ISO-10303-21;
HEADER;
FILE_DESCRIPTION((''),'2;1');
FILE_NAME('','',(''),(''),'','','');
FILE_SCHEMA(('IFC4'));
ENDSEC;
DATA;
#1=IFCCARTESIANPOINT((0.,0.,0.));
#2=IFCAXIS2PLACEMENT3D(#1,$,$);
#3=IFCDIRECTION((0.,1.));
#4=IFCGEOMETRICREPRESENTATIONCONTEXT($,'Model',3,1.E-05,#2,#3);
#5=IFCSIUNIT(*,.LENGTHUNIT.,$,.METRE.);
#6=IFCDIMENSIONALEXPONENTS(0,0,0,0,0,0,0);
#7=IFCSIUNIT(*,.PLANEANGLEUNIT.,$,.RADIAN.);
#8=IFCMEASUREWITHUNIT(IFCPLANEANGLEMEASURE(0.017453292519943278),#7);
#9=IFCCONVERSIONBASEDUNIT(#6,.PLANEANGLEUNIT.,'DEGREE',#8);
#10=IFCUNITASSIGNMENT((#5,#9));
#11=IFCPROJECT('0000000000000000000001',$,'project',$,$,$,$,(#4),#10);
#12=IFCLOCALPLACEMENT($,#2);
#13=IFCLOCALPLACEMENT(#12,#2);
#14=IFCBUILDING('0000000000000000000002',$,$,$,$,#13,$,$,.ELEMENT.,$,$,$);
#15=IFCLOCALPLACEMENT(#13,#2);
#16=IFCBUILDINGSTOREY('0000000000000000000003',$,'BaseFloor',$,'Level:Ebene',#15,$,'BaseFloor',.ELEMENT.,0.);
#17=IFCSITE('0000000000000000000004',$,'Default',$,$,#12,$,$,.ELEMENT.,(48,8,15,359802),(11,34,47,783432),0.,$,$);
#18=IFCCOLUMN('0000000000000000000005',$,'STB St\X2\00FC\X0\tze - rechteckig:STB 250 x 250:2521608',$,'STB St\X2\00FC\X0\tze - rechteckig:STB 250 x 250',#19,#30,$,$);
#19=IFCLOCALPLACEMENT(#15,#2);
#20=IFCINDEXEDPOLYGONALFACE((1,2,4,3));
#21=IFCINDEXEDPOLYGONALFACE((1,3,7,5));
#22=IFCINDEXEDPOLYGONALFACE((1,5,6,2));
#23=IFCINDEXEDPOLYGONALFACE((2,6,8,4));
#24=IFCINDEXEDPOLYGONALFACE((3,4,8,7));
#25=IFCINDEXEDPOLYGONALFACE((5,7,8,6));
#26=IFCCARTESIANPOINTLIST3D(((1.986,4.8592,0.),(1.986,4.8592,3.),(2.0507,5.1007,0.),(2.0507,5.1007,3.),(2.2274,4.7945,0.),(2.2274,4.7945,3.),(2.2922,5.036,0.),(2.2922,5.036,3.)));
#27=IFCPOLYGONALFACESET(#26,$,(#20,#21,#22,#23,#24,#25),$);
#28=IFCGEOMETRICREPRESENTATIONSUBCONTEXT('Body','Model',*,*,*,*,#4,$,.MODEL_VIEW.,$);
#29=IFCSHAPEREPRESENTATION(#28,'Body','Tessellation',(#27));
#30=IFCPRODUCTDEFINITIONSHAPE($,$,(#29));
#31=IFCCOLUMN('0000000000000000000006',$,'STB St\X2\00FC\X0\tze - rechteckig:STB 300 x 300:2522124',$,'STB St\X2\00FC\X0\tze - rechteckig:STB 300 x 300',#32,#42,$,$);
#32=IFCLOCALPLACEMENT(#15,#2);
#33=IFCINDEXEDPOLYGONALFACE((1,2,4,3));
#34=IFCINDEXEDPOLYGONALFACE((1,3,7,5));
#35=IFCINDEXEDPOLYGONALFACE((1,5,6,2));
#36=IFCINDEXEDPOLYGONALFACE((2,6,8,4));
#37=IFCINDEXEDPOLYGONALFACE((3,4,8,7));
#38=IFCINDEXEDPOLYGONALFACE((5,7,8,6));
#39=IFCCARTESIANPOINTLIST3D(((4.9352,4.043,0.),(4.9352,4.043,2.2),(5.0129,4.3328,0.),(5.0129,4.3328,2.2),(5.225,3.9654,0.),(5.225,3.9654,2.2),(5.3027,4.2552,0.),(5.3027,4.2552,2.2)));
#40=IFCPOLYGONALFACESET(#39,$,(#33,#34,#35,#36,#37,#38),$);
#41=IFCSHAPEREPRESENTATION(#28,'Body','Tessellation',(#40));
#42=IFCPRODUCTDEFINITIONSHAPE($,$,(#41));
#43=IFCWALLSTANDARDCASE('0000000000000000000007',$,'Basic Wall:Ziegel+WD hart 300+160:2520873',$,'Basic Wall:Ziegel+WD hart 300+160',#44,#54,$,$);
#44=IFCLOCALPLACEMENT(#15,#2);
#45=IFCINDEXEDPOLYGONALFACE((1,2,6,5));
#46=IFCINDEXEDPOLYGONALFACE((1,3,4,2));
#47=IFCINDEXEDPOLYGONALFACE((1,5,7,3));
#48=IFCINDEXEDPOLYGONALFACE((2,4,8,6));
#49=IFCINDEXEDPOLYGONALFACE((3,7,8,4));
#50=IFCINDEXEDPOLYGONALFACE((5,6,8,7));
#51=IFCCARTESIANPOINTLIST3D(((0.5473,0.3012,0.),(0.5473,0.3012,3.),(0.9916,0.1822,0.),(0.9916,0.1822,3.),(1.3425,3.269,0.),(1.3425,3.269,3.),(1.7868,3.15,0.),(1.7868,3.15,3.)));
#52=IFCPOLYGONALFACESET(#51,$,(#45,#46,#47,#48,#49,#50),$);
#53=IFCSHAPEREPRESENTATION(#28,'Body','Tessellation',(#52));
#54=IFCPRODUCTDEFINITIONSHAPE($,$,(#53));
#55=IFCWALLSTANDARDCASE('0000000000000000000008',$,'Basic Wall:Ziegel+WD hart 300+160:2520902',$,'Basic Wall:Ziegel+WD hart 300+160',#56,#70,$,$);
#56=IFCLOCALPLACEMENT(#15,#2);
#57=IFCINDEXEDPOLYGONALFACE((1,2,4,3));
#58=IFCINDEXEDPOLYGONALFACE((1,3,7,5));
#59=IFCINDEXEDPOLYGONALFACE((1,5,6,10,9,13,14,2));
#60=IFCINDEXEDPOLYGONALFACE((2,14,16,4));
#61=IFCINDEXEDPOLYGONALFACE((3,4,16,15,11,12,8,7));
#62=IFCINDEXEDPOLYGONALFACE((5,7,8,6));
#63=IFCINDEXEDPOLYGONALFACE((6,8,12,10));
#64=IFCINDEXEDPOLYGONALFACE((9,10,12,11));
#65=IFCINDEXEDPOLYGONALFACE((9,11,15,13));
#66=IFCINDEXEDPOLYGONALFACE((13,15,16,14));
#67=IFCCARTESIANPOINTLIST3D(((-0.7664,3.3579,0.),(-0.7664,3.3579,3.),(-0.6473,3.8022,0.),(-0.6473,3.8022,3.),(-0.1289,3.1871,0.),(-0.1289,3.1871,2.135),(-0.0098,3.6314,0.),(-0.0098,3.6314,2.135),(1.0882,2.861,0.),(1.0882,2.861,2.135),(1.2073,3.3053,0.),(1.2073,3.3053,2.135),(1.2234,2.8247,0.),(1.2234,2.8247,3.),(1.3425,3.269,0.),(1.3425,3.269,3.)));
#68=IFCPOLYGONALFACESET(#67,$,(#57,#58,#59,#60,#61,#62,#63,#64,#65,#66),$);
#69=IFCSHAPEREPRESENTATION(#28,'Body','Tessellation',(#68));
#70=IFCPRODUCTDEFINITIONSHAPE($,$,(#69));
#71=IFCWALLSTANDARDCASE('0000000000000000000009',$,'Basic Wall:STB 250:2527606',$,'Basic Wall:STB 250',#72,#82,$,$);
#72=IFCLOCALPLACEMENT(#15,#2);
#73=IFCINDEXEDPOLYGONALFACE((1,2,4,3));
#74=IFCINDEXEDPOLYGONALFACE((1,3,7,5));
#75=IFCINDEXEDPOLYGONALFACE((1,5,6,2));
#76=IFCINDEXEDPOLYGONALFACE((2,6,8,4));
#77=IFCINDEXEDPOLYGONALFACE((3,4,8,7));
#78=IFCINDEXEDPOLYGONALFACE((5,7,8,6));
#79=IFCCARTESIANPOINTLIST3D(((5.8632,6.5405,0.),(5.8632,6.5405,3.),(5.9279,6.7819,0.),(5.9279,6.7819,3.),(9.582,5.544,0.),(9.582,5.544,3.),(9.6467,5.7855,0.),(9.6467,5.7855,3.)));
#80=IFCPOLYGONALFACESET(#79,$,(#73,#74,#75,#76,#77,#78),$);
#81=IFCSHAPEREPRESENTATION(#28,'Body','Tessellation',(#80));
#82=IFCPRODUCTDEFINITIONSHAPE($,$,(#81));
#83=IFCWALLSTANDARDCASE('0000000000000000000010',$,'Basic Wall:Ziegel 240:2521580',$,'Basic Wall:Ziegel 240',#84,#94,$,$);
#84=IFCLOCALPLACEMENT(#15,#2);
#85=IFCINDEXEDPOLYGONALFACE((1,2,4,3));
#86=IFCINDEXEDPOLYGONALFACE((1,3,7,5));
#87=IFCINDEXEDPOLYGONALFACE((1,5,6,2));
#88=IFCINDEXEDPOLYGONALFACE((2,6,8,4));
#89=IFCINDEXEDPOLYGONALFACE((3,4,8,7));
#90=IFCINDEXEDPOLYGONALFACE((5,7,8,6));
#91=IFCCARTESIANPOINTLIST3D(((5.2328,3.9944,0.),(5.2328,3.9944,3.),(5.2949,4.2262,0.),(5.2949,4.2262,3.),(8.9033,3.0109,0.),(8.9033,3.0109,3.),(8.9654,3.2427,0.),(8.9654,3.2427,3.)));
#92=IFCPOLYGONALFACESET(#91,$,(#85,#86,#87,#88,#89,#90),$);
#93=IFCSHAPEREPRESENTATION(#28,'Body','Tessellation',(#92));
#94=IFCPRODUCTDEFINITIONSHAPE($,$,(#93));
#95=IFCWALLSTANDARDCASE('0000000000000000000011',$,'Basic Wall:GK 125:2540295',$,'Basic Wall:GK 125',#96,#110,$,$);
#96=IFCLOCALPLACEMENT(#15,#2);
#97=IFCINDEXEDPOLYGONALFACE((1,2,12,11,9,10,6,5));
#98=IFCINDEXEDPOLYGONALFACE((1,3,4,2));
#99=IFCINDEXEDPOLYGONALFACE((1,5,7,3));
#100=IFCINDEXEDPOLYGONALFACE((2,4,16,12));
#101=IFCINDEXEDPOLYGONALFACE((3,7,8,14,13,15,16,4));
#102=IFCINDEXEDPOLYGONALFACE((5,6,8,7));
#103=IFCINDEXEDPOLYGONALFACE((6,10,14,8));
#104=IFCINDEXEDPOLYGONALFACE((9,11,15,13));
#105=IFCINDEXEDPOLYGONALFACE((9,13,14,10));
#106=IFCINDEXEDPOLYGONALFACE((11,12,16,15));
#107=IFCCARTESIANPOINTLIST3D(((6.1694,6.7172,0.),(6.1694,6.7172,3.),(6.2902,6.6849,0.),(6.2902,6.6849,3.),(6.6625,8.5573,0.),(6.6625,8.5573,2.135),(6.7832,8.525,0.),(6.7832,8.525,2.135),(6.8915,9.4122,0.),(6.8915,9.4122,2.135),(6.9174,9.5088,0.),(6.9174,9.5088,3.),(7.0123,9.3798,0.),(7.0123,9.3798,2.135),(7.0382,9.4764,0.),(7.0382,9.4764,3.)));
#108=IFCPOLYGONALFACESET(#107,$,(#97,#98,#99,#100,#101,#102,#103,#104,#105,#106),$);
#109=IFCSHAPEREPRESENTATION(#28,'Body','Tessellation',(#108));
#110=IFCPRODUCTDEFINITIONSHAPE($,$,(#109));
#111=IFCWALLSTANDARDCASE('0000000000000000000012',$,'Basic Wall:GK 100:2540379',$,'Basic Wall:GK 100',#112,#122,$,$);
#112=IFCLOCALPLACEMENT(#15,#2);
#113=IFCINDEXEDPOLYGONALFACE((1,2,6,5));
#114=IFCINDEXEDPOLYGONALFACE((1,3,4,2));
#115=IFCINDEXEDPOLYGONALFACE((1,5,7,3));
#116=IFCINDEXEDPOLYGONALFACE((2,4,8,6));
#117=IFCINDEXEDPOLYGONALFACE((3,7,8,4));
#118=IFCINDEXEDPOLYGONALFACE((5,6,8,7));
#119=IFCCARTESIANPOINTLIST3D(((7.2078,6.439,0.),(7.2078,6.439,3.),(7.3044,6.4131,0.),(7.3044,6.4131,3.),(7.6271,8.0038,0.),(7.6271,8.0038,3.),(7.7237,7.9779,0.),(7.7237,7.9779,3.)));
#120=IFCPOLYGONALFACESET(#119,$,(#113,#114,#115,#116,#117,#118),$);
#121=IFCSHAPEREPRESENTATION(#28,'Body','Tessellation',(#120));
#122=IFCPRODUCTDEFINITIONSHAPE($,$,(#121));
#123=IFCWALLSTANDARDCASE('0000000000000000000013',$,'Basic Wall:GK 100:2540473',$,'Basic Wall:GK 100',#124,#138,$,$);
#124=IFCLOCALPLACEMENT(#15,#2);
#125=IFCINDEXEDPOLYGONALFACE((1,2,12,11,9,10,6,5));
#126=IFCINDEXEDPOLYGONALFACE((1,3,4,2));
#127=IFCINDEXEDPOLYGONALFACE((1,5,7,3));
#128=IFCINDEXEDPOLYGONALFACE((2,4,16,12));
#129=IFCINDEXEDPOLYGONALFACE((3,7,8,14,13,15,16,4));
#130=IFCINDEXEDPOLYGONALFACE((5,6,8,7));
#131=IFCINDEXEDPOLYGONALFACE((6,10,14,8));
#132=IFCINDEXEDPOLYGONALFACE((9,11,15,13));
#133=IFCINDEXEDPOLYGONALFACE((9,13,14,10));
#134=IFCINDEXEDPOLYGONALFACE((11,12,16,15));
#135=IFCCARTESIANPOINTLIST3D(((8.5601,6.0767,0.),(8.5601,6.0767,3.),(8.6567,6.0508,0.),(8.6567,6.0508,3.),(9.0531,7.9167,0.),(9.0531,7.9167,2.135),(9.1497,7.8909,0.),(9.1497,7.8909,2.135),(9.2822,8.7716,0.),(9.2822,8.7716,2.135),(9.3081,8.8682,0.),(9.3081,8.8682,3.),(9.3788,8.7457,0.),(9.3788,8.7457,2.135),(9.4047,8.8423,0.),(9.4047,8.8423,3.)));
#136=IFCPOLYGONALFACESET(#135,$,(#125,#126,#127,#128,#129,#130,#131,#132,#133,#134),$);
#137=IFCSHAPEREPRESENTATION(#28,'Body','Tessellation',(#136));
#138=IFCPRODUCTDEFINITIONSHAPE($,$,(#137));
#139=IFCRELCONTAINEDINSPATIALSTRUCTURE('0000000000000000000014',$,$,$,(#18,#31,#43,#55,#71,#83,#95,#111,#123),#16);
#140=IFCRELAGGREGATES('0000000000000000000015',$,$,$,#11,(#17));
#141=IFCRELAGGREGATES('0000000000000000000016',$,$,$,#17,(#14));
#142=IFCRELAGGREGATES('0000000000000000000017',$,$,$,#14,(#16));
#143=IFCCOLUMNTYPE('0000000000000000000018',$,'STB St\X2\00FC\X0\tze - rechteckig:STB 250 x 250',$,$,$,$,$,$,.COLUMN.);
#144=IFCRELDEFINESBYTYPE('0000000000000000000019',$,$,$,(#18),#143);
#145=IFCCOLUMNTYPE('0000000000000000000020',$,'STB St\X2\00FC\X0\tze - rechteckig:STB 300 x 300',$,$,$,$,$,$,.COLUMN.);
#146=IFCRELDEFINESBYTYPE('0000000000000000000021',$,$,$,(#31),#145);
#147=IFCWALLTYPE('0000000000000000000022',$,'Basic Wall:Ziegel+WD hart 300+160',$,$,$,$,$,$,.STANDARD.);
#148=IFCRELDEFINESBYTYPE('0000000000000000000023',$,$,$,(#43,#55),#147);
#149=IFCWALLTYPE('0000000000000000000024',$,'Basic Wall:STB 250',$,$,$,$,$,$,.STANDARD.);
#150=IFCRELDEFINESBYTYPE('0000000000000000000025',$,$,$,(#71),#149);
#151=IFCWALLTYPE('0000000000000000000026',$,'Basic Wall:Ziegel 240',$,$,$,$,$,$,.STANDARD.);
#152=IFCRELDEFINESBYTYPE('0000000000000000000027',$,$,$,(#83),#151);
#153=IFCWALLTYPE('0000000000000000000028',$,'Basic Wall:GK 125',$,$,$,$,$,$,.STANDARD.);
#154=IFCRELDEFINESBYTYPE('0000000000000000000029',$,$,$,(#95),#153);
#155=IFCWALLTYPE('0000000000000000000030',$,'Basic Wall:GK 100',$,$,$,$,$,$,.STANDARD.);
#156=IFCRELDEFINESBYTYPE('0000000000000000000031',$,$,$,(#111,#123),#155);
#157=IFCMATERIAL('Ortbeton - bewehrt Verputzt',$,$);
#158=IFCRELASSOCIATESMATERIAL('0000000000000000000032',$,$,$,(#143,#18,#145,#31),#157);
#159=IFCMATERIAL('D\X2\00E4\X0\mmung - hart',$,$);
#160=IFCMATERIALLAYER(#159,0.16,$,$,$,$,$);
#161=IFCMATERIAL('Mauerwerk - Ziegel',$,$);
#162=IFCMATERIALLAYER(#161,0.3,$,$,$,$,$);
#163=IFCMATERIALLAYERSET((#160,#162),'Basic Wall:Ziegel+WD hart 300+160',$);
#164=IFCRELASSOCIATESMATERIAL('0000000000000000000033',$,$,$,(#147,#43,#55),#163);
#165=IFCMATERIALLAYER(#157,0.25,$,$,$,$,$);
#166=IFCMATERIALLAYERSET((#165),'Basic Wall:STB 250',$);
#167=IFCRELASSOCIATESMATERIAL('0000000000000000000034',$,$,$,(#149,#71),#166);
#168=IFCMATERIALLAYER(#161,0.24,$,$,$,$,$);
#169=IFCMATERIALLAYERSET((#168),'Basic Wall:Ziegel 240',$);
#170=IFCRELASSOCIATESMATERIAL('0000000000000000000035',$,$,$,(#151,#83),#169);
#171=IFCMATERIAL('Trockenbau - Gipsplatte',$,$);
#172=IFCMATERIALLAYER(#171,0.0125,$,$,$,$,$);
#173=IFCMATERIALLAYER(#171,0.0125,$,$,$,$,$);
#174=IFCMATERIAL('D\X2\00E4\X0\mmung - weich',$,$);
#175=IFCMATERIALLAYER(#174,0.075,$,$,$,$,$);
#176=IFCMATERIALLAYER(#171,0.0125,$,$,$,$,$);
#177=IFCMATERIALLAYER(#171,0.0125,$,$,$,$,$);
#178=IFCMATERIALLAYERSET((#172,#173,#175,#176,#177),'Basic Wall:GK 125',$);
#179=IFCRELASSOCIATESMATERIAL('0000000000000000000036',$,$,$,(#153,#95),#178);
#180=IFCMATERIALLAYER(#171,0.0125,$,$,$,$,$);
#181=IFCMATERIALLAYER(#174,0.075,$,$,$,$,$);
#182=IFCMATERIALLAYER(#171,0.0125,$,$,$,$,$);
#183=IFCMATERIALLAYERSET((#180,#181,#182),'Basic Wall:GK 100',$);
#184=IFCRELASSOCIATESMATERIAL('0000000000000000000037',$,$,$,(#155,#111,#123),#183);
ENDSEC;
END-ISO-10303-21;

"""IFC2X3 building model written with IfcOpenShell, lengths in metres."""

from ifc_helpers import new_model, entity, si_unit, converted_unit, direction, frame, frame_2d, origin, place, context, subcontext, project, spatial, rectangle, extrude, source, transform, mapped, material, layer, layer_set, layer_usage, type_object, type_shapes, element, save


model = new_model("IFC2X3")

# Units and contexts
model_context = context("Model", 3, precision=1e-05, world=origin(), true_north=direction((0.0, 1.0)))
body_context = subcontext(model_context, "Body", "Model", "MODEL_VIEW")
ifc_project = project(units=[si_unit("LENGTHUNIT", "METRE"), converted_unit("PLANEANGLEUNIT", "DEGREE", entity("IfcPlaneAngleMeasure", 0.017453292519943278), si_unit("PLANEANGLEUNIT", "RADIAN"), dimensions=[0, 0, 0, 0, 0, 0, 0])], contexts=[model_context])

# Site, building, storey
site_placement = place(None, origin())
site = spatial("IfcSite", under=ifc_project, at=site_placement, Name="Default", CompositionType="ELEMENT", RefLatitude=(48, 8, 15, 359802), RefLongitude=(11, 34, 47, 783432), RefElevation=0.0)
building_placement = place(site_placement, origin())
building = spatial("IfcBuilding", under=site, at=building_placement, CompositionType="ELEMENT")
storey_placement = place(building_placement, origin())
storey = spatial("IfcBuildingStorey", under=building, at=storey_placement, Name="BaseFloor", ObjectType="Level:Ebene", LongName="BaseFloor", CompositionType="ELEMENT", Elevation=0.0)

# Columns
ifc_material_1 = material(Name="Ortbeton - bewehrt Verputzt")
column_type_1 = type_object("IfcColumnType", Name="STB Stütze - rechteckig:STB 250 x 250", PredefinedType="COLUMN", material=ifc_material_1)
shared_shape_1 = source(origin(), body_context, "Body", "SweptSolid", [
    extrude(rectangle(XDim=0.25, YDim=0.25, at=frame_2d((0.0, 0.0), x_axis=(1.0, 0.0))), frame((2.1391, 4.9476, 0.0), z_axis=(0.0, 0.0, 1.0), x_axis=(-0.258819, -0.965926, 0.0)), (0.0, 0.0, 1.0), 3.0),
])
type_shapes(column_type_1, [shared_shape_1])
column_1_placement = place(storey_placement, origin())
element("IfcColumn", 1, at=column_1_placement, inside=storey, type_object=column_type_1, material=ifc_material_1, Name="STB Stütze - rechteckig:STB 250 x 250:2521608", ObjectType="STB Stütze - rechteckig:STB 250 x 250", context=body_context, shape_type="MappedRepresentation", body=[
    mapped(shared_shape_1, transform((0.0, 0.0, 0.0), scale=1.0)),
])
column_type_2 = type_object("IfcColumnType", Name="STB Stütze - rechteckig:STB 300 x 300", PredefinedType="COLUMN", material=ifc_material_1)
shared_shape_2 = source(origin(), body_context, "Body", "SweptSolid", [
    extrude(rectangle(XDim=0.3, YDim=0.3, at=frame_2d((0.0, 0.0), x_axis=(1.0, 0.0))), frame((5.1189, 4.1491, 0.0), z_axis=(0.0, 0.0, 1.0), x_axis=(-0.258819, -0.965926, 0.0)), (0.0, 0.0, 1.0), 2.2),
])
type_shapes(column_type_2, [shared_shape_2])
column_2_placement = place(storey_placement, origin())
element("IfcColumn", 2, at=column_2_placement, inside=storey, type_object=column_type_2, material=ifc_material_1, Name="STB Stütze - rechteckig:STB 300 x 300:2522124", ObjectType="STB Stütze - rechteckig:STB 300 x 300", context=body_context, shape_type="MappedRepresentation", body=[
    mapped(shared_shape_2, transform((0.0, 0.0, 0.0), scale=1.0)),
])

# Wall
ifc_material_2 = material(Name="Dämmung - hart")
ifc_layer_1 = layer(ifc_material_2, 0.16)
ifc_material_3 = material(Name="Mauerwerk - Ziegel")
ifc_layer_2 = layer(ifc_material_3, 0.3)
ifc_layer_set_1 = layer_set([ifc_layer_1, ifc_layer_2], Name="Basic Wall:Ziegel+WD hart 300+160")
ifc_layer_usage_1 = layer_usage(ifc_layer_set_1, "AXIS2", "NEGATIVE", 0.23)
wall_type_1 = type_object("IfcWallType", Name="Basic Wall:Ziegel+WD hart 300+160", PredefinedType="STANDARD", material=ifc_layer_set_1)
wall_1_placement = place(storey_placement, frame((0.7694, 0.2417, 0.0), z_axis=(0.0, 0.0, 1.0), x_axis=(0.258819, 0.965926, 0.0)))
element("IfcWallStandardCase", 3, at=wall_1_placement, inside=storey, type_object=wall_type_1, material=ifc_layer_usage_1, Name="Basic Wall:Ziegel+WD hart 300+160:2520873", ObjectType="Basic Wall:Ziegel+WD hart 300+160", context=body_context, shape_type="SweptSolid", body=[
    extrude(rectangle(XDim=3.0725, YDim=0.46, at=frame_2d((1.5363, 0.0), x_axis=(-1.0, 0.0))), origin(), (0.0, 0.0, 1.0), 3.0),
])

# Wall, opening
ifc_layer_usage_2 = layer_usage(ifc_layer_set_1, "AXIS2", "NEGATIVE", 0.23)
wall_2_placement = place(storey_placement, frame((1.283, 3.0469, 0.0), z_axis=(0.0, 0.0, 1.0), x_axis=(-0.965926, 0.258819, 0.0)))
wall_2 = element("IfcWallStandardCase", 4, at=wall_2_placement, inside=storey, type_object=wall_type_1, material=ifc_layer_usage_2, Name="Basic Wall:Ziegel+WD hart 300+160:2520902", ObjectType="Basic Wall:Ziegel+WD hart 300+160", context=body_context, shape_type="SweptSolid", body=[
    extrude(rectangle(XDim=2.06, YDim=0.46, at=frame_2d((1.03, 0.0), x_axis=(1.0, 0.0))), origin(), (0.0, 0.0, 1.0), 3.0),
])
opening_1_placement = place(wall_2_placement, frame((1.4, 0.23, -0.18)))
element("IfcOpeningElement", 5, at=opening_1_placement, cuts=wall_2, ObjectType="Opening", context=body_context, shape_type="SweptSolid", body=[
    extrude(rectangle(XDim=2.315, YDim=1.26, at=frame_2d((1.1575, 0.63), x_axis=(-1.0, 0.0))), frame((0.0, 0.0, 0.0), z_axis=(0.0, -1.0, 0.0), x_axis=(0.0, 0.0, 1.0)), (0.0, 0.0, 1.0), 0.46),
])
ifc_layer_3 = layer(ifc_material_1, 0.25)
ifc_layer_set_2 = layer_set([ifc_layer_3], Name="Basic Wall:STB 250")
wall_type_2 = type_object("IfcWallType", Name="Basic Wall:STB 250", PredefinedType="STANDARD", material=ifc_layer_set_2)

# Walls
ifc_layer_usage_3 = layer_usage(ifc_layer_set_2, "AXIS2", "NEGATIVE", 0.125)
wall_3_placement = place(storey_placement, frame((5.8956, 6.6612, 0.0), z_axis=(0.0, 0.0, 1.0), x_axis=(0.965926, -0.258819, 0.0)))
element("IfcWallStandardCase", 6, at=wall_3_placement, inside=storey, type_object=wall_type_2, material=ifc_layer_usage_3, Name="Basic Wall:STB 250:2527606", ObjectType="Basic Wall:STB 250", context=body_context, shape_type="SweptSolid", body=[
    extrude(rectangle(XDim=3.85, YDim=0.25, at=frame_2d((1.925, 0.0), x_axis=(-1.0, 0.0))), origin(), (0.0, 0.0, 1.0), 3.0),
])
ifc_layer_4 = layer(ifc_material_3, 0.24)
ifc_layer_set_3 = layer_set([ifc_layer_4], Name="Basic Wall:Ziegel 240")
ifc_layer_usage_4 = layer_usage(ifc_layer_set_3, "AXIS2", "NEGATIVE", 0.12)
wall_type_3 = type_object("IfcWallType", Name="Basic Wall:Ziegel 240", PredefinedType="STANDARD", material=ifc_layer_set_3)
wall_4_placement = place(storey_placement, frame((8.9343, 3.1268, 0.0), z_axis=(0.0, 0.0, 1.0), x_axis=(-0.965926, 0.258819, 0.0)))
element("IfcWallStandardCase", 7, at=wall_4_placement, inside=storey, type_object=wall_type_3, material=ifc_layer_usage_4, Name="Basic Wall:Ziegel 240:2521580", ObjectType="Basic Wall:Ziegel 240", context=body_context, shape_type="SweptSolid", body=[
    extrude(rectangle(XDim=3.8, YDim=0.24, at=frame_2d((1.9, 0.0), x_axis=(-1.0, 0.0))), origin(), (0.0, 0.0, 1.0), 3.0),
])

# Wall, opening
ifc_material_4 = material(Name="Trockenbau - Gipsplatte")
ifc_layer_5 = layer(ifc_material_4, 0.0125)
ifc_layer_6 = layer(ifc_material_4, 0.0125)
ifc_material_5 = material(Name="Dämmung - weich")
ifc_layer_7 = layer(ifc_material_5, 0.075)
ifc_layer_8 = layer(ifc_material_4, 0.0125)
ifc_layer_9 = layer(ifc_material_4, 0.0125)
ifc_layer_set_4 = layer_set([ifc_layer_5, ifc_layer_6, ifc_layer_7, ifc_layer_8, ifc_layer_9], Name="Basic Wall:GK 125")
ifc_layer_usage_5 = layer_usage(ifc_layer_set_4, "AXIS2", "NEGATIVE", 0.0625)
wall_type_4 = type_object("IfcWallType", Name="Basic Wall:GK 125", PredefinedType="STANDARD", material=ifc_layer_set_4)
wall_5_placement = place(storey_placement, frame((6.2298, 6.7011, 0.0), z_axis=(0.0, 0.0, 1.0), x_axis=(0.258819, 0.965926, 0.0)))
wall_5 = element("IfcWallStandardCase", 8, at=wall_5_placement, inside=storey, type_object=wall_type_4, material=ifc_layer_usage_5, Name="Basic Wall:GK 125:2540295", ObjectType="Basic Wall:GK 125", context=body_context, shape_type="SweptSolid", body=[
    extrude(rectangle(XDim=2.89, YDim=0.125, at=frame_2d((1.445, 0.0), x_axis=(-1.0, 0.0))), origin(), (0.0, 0.0, 1.0), 3.0),
])
opening_2_placement = place(wall_5_placement, frame((1.905, -0.0625, -0.18)))
element("IfcOpeningElement", 9, at=opening_2_placement, cuts=wall_5, ObjectType="Opening", context=body_context, shape_type="SweptSolid", body=[
    extrude(rectangle(XDim=2.315, YDim=0.885, at=frame_2d((1.1575, 0.4425), x_axis=(-1.0, 0.0))), frame((0.0, 0.0, 0.0), z_axis=(0.0, 1.0, 0.0), x_axis=(0.0, 0.0, 1.0)), (0.0, 0.0, 1.0), 0.125),
])

# Wall
ifc_layer_10 = layer(ifc_material_4, 0.0125)
ifc_layer_11 = layer(ifc_material_5, 0.075)
ifc_layer_12 = layer(ifc_material_4, 0.0125)
ifc_layer_set_5 = layer_set([ifc_layer_10, ifc_layer_11, ifc_layer_12], Name="Basic Wall:GK 100")
ifc_layer_usage_6 = layer_usage(ifc_layer_set_5, "AXIS2", "NEGATIVE", 0.05)
wall_type_5 = type_object("IfcWallType", Name="Basic Wall:GK 100", PredefinedType="STANDARD", material=ifc_layer_set_5)
wall_6_placement = place(storey_placement, frame((7.2561, 6.4261, 0.0), z_axis=(0.0, 0.0, 1.0), x_axis=(0.258819, 0.965926, 0.0)))
element("IfcWallStandardCase", 10, at=wall_6_placement, inside=storey, type_object=wall_type_5, material=ifc_layer_usage_6, Name="Basic Wall:GK 100:2540379", ObjectType="Basic Wall:GK 100", context=body_context, shape_type="SweptSolid", body=[
    extrude(rectangle(XDim=1.62, YDim=0.1, at=frame_2d((0.81, 0.0), x_axis=(-1.0, 0.0))), origin(), (0.0, 0.0, 1.0), 3.0),
])

# Wall, opening
ifc_layer_usage_7 = layer_usage(ifc_layer_set_5, "AXIS2", "NEGATIVE", 0.05)
wall_7_placement = place(storey_placement, frame((8.6084, 6.0637, 0.0), z_axis=(0.0, 0.0, 1.0), x_axis=(0.258819, 0.965926, 0.0)))
wall_7 = element("IfcWallStandardCase", 11, at=wall_7_placement, inside=storey, type_object=wall_type_5, material=ifc_layer_usage_7, Name="Basic Wall:GK 100:2540473", ObjectType="Basic Wall:GK 100", context=body_context, shape_type="SweptSolid", body=[
    extrude(rectangle(XDim=2.89, YDim=0.1, at=frame_2d((1.445, 0.0), x_axis=(-1.0, 0.0))), origin(), (0.0, 0.0, 1.0), 3.0),
])
opening_3_placement = place(wall_7_placement, frame((2.79, 0.05, -0.18)))
element("IfcOpeningElement", 12, at=opening_3_placement, cuts=wall_7, ObjectType="Opening", context=body_context, shape_type="SweptSolid", body=[
    extrude(rectangle(XDim=2.315, YDim=0.885, at=frame_2d((1.1575, 0.4425), x_axis=(-1.0, 0.0))), frame((0.0, 0.0, 0.0), z_axis=(0.0, -1.0, 0.0), x_axis=(0.0, 0.0, 1.0)), (0.0, 0.0, 1.0), 0.1),
])

save(model, "model.ifc")
